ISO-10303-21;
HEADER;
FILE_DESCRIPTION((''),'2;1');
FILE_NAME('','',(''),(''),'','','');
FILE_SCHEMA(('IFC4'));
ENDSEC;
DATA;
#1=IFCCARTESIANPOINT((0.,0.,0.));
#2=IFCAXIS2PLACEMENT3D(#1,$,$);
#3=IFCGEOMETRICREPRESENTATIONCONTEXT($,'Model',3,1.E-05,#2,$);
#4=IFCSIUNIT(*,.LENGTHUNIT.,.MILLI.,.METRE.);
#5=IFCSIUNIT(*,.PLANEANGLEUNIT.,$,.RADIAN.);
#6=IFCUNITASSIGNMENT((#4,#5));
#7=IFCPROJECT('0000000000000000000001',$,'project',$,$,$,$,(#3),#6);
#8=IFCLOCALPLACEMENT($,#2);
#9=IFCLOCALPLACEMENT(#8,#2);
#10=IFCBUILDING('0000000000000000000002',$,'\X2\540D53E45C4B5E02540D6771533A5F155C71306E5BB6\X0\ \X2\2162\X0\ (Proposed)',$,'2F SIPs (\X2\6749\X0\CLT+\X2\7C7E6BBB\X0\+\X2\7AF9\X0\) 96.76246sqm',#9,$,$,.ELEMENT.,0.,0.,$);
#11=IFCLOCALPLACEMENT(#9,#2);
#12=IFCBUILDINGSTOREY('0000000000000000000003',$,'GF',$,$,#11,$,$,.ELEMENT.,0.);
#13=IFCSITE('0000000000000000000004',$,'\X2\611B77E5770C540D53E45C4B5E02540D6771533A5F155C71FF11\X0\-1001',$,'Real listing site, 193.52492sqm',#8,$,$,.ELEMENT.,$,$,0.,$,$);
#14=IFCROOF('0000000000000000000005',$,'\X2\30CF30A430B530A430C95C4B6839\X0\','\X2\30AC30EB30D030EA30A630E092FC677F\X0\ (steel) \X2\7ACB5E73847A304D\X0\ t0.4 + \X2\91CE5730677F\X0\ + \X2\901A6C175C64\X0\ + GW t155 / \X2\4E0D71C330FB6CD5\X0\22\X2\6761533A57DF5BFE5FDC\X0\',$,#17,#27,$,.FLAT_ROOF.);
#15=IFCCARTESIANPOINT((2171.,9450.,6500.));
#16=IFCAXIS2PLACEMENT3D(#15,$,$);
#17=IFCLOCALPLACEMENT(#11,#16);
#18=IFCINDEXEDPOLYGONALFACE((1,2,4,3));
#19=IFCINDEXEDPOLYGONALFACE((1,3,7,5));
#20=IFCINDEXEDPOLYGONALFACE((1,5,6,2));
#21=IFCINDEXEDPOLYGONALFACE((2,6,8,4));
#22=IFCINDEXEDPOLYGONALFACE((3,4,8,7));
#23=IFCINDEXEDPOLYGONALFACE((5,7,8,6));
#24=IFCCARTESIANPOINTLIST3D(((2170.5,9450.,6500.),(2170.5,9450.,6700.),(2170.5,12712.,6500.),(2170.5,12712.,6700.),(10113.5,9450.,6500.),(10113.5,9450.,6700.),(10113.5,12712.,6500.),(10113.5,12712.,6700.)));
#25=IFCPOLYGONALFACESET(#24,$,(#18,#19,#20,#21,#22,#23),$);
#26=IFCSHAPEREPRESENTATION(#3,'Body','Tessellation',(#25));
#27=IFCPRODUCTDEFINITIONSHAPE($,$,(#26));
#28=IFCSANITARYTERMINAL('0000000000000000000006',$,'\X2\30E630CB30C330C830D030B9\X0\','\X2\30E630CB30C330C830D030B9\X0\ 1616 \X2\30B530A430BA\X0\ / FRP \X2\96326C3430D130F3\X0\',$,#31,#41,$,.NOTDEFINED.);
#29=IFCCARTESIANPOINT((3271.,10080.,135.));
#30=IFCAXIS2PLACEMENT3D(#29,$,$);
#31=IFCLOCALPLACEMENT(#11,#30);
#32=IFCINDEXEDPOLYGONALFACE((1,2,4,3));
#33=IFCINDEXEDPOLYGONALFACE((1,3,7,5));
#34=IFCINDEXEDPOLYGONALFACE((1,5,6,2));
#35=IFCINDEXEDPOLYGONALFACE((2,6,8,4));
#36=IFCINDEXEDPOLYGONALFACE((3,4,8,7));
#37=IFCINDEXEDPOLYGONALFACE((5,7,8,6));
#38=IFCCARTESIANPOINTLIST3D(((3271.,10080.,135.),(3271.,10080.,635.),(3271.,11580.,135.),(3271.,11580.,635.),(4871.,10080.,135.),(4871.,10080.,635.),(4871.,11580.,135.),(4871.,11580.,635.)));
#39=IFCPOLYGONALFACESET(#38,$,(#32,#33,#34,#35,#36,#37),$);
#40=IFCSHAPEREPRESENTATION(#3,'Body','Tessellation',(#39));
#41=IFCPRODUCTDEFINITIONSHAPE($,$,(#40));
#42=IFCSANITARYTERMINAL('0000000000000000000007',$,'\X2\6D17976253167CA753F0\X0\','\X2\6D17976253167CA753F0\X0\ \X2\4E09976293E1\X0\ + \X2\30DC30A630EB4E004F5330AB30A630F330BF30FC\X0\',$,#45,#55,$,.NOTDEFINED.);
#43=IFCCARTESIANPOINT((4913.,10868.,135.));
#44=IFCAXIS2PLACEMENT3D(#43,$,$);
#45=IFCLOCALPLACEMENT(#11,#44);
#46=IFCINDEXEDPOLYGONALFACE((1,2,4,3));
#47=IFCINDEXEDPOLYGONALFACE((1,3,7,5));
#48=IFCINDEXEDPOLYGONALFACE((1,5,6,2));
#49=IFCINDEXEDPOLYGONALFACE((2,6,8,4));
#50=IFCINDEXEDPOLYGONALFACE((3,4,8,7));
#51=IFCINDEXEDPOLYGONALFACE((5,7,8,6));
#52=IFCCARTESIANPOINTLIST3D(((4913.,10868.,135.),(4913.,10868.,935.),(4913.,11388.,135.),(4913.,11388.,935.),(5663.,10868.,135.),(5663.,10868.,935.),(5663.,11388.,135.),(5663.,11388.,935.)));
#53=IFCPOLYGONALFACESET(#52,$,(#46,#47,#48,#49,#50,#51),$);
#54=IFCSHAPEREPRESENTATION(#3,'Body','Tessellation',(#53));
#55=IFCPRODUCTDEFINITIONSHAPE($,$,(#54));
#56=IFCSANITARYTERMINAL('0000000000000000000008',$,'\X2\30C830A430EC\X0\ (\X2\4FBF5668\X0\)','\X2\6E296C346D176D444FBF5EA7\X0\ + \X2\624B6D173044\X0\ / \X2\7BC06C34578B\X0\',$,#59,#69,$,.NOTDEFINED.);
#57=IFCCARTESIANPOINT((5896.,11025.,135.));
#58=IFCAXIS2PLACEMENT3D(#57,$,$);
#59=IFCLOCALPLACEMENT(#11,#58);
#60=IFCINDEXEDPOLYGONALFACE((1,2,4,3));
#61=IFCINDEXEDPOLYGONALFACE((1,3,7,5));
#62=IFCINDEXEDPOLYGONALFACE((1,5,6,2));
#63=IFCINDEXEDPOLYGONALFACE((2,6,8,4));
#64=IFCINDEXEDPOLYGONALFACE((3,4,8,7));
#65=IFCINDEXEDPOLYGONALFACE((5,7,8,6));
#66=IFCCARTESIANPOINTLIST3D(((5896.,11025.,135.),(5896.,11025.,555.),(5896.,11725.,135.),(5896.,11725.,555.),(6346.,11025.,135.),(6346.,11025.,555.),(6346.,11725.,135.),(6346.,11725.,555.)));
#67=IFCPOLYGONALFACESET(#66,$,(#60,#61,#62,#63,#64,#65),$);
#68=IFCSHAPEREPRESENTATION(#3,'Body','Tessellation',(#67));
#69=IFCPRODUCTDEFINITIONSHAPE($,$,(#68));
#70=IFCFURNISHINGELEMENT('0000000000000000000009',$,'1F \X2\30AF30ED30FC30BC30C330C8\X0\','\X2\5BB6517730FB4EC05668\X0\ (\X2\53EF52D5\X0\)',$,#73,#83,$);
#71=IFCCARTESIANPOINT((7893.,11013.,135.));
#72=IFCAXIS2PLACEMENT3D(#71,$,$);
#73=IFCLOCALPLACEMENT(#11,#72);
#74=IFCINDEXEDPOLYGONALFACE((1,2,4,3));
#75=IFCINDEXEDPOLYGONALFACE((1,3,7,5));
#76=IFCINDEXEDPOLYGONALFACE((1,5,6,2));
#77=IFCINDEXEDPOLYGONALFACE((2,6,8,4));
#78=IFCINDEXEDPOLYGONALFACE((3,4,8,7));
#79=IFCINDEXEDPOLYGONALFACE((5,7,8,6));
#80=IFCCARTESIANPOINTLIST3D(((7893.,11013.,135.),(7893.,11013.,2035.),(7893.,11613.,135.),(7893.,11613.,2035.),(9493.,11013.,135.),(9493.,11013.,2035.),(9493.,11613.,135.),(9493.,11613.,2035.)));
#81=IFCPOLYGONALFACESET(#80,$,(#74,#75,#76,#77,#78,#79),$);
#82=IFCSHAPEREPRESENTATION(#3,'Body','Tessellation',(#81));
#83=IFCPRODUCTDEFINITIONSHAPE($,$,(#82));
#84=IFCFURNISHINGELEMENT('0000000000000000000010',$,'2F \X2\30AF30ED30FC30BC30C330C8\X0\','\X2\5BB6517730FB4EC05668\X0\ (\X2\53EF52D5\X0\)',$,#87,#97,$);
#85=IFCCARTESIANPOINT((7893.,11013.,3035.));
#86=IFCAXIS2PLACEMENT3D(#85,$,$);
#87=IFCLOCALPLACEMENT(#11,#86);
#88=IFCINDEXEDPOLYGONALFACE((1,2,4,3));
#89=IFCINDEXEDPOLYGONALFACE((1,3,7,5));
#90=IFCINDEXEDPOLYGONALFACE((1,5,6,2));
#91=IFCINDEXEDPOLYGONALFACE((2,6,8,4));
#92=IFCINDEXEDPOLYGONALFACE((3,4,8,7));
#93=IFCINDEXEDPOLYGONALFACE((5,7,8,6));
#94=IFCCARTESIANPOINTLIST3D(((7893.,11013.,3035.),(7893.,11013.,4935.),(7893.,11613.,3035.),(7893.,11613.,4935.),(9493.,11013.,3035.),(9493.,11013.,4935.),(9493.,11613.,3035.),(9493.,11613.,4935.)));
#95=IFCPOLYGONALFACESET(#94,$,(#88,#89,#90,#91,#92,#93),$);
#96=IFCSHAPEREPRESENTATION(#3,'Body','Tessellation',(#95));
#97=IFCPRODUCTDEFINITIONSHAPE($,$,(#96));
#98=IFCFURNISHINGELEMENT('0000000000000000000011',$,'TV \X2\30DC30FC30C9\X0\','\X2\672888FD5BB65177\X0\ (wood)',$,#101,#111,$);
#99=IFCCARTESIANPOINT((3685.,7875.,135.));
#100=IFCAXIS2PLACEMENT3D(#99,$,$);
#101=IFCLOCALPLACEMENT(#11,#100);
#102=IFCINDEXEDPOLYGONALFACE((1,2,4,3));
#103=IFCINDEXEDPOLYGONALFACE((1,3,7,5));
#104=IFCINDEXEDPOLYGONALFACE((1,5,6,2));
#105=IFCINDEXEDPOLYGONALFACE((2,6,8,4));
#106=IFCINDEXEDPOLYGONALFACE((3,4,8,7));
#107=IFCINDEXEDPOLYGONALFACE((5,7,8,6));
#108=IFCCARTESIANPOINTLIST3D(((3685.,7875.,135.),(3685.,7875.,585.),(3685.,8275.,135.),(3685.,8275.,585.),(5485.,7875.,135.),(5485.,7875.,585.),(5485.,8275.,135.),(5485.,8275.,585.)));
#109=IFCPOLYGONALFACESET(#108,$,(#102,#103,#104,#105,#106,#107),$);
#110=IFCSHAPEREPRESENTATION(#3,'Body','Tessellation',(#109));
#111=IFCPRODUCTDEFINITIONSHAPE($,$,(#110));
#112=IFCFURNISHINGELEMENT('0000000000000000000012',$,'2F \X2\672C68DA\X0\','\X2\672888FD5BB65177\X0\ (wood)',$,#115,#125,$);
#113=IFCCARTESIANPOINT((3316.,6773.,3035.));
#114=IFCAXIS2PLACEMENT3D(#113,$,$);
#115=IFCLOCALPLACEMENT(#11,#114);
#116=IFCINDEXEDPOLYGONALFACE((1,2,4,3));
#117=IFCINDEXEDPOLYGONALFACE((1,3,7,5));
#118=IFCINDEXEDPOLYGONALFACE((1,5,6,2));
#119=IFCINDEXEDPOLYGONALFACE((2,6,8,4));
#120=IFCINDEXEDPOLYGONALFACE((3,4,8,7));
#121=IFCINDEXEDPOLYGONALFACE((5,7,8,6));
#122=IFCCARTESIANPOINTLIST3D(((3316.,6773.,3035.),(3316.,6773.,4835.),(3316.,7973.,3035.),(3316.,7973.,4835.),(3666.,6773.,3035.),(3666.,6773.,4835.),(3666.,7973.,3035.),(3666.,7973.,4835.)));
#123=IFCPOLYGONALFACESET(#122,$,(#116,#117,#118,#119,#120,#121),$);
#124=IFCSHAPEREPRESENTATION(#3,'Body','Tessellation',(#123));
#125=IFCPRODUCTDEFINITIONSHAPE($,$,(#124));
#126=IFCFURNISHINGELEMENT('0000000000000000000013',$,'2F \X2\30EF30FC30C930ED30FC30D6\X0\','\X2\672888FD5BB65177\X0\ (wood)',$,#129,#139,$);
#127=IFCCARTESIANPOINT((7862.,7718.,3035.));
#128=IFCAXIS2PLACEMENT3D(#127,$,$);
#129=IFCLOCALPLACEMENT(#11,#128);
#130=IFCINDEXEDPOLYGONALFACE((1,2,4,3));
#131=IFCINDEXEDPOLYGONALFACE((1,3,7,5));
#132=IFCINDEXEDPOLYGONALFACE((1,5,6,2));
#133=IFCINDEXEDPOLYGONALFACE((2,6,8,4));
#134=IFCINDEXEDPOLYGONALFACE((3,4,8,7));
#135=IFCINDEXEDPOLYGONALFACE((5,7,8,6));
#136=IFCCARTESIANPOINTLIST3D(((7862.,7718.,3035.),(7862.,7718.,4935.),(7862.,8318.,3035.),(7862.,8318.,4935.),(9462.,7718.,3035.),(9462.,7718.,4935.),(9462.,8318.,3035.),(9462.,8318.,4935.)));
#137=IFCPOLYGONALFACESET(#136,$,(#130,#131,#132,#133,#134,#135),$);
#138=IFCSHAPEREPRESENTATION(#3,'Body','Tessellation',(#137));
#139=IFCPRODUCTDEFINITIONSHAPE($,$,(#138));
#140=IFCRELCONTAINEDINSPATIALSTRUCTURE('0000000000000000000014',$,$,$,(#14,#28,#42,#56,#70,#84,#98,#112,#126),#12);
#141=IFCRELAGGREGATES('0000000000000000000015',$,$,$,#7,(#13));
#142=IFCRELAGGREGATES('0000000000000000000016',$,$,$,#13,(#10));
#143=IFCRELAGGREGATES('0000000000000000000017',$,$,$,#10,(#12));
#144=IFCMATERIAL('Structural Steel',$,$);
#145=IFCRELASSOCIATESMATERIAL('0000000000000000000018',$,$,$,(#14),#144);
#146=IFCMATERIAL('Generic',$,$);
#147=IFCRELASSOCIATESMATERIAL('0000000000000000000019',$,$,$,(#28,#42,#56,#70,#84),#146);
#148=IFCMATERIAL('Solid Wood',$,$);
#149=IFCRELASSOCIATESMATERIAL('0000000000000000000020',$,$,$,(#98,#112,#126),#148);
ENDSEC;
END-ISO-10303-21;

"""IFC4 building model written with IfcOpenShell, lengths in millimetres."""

from ifc_helpers import new_model, si_unit, frame, frame_2d, origin, place, context, project, spatial, rectangle, extrude, material, element, save


model = new_model("IFC4")

# Units and contexts
model_context = context("Model", 3, precision=1e-05, world=origin())
ifc_project = project(units=[si_unit("LENGTHUNIT", "METRE", prefix="MILLI"), si_unit("PLANEANGLEUNIT", "RADIAN")], contexts=[model_context])

# Site, building, storey
site_placement = place(None, origin())
site = spatial("IfcSite", under=ifc_project, at=site_placement, Name="愛知県名古屋市名東区引山１-1001", ObjectType="Real listing site, 193.52492sqm", CompositionType="ELEMENT", RefElevation=0.0)
building_placement = place(site_placement, origin())
building = spatial("IfcBuilding", under=site, at=building_placement, Name="名古屋市名東区引山の家 Ⅲ (Proposed)", ObjectType="2F SIPs (杉CLT+籾殻+竹) 96.76246sqm", CompositionType="ELEMENT", ElevationOfRefHeight=0.0, ElevationOfTerrain=0.0)
storey_placement = place(building_placement, origin())
storey = spatial("IfcBuildingStorey", under=building, at=storey_placement, Name="GF", CompositionType="ELEMENT", Elevation=0.0)

# Shared definitions
ifc_material_1 = material(Name="Solid Wood")

# Roof
ifc_material_2 = material(Name="Structural Steel")
roof_placement = place(storey_placement, frame((2171.0, 9450.0, 6500.0)))
element("IfcRoof", 1, at=roof_placement, inside=storey, material=ifc_material_2, Name="ハイサイド屋根", Description="ガルバリウム鋼板 (steel) 立平葺き t0.4 + 野地板 + 通気層 + GW t155 / 不燃・法22条区域対応", PredefinedType="FLAT_ROOF", context=model_context, shape_type="SweptSolid", body=[
    extrude(rectangle(XDim=7943.0, YDim=3262.0, at=frame_2d((3971.0, 1631.0))), frame((2171.0, 9450.0, 6500.0)), (0.0, 0.0, 1.0), 200.0),
])

# Sanitary terminals
ifc_material_3 = material(Name="Generic")
sanitary_terminal_1_placement = place(storey_placement, frame((3271.0, 10080.0, 135.0)))
element("IfcSanitaryTerminal", 2, at=sanitary_terminal_1_placement, inside=storey, material=ifc_material_3, Name="ユニットバス", Description="ユニットバス 1616 サイズ / FRP 防水パン", PredefinedType="NOTDEFINED", context=model_context, shape_type="SweptSolid", body=[
    extrude(rectangle(XDim=1600.0, YDim=1500.0, at=frame_2d((800.0, 750.0))), frame((3271.0, 10080.0, 135.0)), (0.0, 0.0, 1.0), 500.0),
])
sanitary_terminal_2_placement = place(storey_placement, frame((4913.0, 10868.0, 135.0)))
element("IfcSanitaryTerminal", 3, at=sanitary_terminal_2_placement, inside=storey, material=ifc_material_3, Name="洗面化粧台", Description="洗面化粧台 三面鏡 + ボウル一体カウンター", PredefinedType="NOTDEFINED", context=model_context, shape_type="SweptSolid", body=[
    extrude(rectangle(XDim=750.0, YDim=520.0, at=frame_2d((375.0, 260.0))), frame((4913.0, 10868.0, 135.0)), (0.0, 0.0, 1.0), 800.0),
])
sanitary_terminal_3_placement = place(storey_placement, frame((5896.0, 11025.0, 135.0)))
element("IfcSanitaryTerminal", 4, at=sanitary_terminal_3_placement, inside=storey, material=ifc_material_3, Name="トイレ (便器)", Description="温水洗浄便座 + 手洗い / 節水型", PredefinedType="NOTDEFINED", context=model_context, shape_type="SweptSolid", body=[
    extrude(rectangle(XDim=450.0, YDim=700.0, at=frame_2d((225.0, 350.0))), frame((5896.0, 11025.0, 135.0)), (0.0, 0.0, 1.0), 420.0),
])

# Furnishing elements
furnishing_1_placement = place(storey_placement, frame((7893.0, 11013.0, 135.0)))
element("IfcFurnishingElement", 5, at=furnishing_1_placement, inside=storey, material=ifc_material_3, Name="1F クローゼット", Description="家具・什器 (可動)", context=model_context, shape_type="SweptSolid", body=[
    extrude(rectangle(XDim=1600.0, YDim=600.0, at=frame_2d((800.0, 300.0))), frame((7893.0, 11013.0, 135.0)), (0.0, 0.0, 1.0), 1900.0),
])
furnishing_2_placement = place(storey_placement, frame((7893.0, 11013.0, 3035.0)))
element("IfcFurnishingElement", 6, at=furnishing_2_placement, inside=storey, material=ifc_material_3, Name="2F クローゼット", Description="家具・什器 (可動)", context=model_context, shape_type="SweptSolid", body=[
    extrude(rectangle(XDim=1600.0, YDim=600.0, at=frame_2d((800.0, 300.0))), frame((7893.0, 11013.0, 3035.0)), (0.0, 0.0, 1.0), 1900.0),
])
furnishing_3_placement = place(storey_placement, frame((3685.0, 7875.0, 135.0)))
element("IfcFurnishingElement", 7, at=furnishing_3_placement, inside=storey, material=ifc_material_1, Name="TV ボード", Description="木製家具 (wood)", context=model_context, shape_type="SweptSolid", body=[
    extrude(rectangle(XDim=1800.0, YDim=400.0, at=frame_2d((900.0, 200.0))), frame((3685.0, 7875.0, 135.0)), (0.0, 0.0, 1.0), 450.0),
])
furnishing_4_placement = place(storey_placement, frame((3316.0, 6773.0, 3035.0)))
element("IfcFurnishingElement", 8, at=furnishing_4_placement, inside=storey, material=ifc_material_1, Name="2F 本棚", Description="木製家具 (wood)", context=model_context, shape_type="SweptSolid", body=[
    extrude(rectangle(XDim=350.0, YDim=1200.0, at=frame_2d((175.0, 600.0))), frame((3316.0, 6773.0, 3035.0)), (0.0, 0.0, 1.0), 1800.0),
])
furnishing_5_placement = place(storey_placement, frame((7862.0, 7718.0, 3035.0)))
element("IfcFurnishingElement", 9, at=furnishing_5_placement, inside=storey, material=ifc_material_1, Name="2F ワードローブ", Description="木製家具 (wood)", context=model_context, shape_type="SweptSolid", body=[
    extrude(rectangle(XDim=1600.0, YDim=600.0, at=frame_2d((800.0, 300.0))), frame((7862.0, 7718.0, 3035.0)), (0.0, 0.0, 1.0), 1900.0),
])

save(model, "model.ifc")
